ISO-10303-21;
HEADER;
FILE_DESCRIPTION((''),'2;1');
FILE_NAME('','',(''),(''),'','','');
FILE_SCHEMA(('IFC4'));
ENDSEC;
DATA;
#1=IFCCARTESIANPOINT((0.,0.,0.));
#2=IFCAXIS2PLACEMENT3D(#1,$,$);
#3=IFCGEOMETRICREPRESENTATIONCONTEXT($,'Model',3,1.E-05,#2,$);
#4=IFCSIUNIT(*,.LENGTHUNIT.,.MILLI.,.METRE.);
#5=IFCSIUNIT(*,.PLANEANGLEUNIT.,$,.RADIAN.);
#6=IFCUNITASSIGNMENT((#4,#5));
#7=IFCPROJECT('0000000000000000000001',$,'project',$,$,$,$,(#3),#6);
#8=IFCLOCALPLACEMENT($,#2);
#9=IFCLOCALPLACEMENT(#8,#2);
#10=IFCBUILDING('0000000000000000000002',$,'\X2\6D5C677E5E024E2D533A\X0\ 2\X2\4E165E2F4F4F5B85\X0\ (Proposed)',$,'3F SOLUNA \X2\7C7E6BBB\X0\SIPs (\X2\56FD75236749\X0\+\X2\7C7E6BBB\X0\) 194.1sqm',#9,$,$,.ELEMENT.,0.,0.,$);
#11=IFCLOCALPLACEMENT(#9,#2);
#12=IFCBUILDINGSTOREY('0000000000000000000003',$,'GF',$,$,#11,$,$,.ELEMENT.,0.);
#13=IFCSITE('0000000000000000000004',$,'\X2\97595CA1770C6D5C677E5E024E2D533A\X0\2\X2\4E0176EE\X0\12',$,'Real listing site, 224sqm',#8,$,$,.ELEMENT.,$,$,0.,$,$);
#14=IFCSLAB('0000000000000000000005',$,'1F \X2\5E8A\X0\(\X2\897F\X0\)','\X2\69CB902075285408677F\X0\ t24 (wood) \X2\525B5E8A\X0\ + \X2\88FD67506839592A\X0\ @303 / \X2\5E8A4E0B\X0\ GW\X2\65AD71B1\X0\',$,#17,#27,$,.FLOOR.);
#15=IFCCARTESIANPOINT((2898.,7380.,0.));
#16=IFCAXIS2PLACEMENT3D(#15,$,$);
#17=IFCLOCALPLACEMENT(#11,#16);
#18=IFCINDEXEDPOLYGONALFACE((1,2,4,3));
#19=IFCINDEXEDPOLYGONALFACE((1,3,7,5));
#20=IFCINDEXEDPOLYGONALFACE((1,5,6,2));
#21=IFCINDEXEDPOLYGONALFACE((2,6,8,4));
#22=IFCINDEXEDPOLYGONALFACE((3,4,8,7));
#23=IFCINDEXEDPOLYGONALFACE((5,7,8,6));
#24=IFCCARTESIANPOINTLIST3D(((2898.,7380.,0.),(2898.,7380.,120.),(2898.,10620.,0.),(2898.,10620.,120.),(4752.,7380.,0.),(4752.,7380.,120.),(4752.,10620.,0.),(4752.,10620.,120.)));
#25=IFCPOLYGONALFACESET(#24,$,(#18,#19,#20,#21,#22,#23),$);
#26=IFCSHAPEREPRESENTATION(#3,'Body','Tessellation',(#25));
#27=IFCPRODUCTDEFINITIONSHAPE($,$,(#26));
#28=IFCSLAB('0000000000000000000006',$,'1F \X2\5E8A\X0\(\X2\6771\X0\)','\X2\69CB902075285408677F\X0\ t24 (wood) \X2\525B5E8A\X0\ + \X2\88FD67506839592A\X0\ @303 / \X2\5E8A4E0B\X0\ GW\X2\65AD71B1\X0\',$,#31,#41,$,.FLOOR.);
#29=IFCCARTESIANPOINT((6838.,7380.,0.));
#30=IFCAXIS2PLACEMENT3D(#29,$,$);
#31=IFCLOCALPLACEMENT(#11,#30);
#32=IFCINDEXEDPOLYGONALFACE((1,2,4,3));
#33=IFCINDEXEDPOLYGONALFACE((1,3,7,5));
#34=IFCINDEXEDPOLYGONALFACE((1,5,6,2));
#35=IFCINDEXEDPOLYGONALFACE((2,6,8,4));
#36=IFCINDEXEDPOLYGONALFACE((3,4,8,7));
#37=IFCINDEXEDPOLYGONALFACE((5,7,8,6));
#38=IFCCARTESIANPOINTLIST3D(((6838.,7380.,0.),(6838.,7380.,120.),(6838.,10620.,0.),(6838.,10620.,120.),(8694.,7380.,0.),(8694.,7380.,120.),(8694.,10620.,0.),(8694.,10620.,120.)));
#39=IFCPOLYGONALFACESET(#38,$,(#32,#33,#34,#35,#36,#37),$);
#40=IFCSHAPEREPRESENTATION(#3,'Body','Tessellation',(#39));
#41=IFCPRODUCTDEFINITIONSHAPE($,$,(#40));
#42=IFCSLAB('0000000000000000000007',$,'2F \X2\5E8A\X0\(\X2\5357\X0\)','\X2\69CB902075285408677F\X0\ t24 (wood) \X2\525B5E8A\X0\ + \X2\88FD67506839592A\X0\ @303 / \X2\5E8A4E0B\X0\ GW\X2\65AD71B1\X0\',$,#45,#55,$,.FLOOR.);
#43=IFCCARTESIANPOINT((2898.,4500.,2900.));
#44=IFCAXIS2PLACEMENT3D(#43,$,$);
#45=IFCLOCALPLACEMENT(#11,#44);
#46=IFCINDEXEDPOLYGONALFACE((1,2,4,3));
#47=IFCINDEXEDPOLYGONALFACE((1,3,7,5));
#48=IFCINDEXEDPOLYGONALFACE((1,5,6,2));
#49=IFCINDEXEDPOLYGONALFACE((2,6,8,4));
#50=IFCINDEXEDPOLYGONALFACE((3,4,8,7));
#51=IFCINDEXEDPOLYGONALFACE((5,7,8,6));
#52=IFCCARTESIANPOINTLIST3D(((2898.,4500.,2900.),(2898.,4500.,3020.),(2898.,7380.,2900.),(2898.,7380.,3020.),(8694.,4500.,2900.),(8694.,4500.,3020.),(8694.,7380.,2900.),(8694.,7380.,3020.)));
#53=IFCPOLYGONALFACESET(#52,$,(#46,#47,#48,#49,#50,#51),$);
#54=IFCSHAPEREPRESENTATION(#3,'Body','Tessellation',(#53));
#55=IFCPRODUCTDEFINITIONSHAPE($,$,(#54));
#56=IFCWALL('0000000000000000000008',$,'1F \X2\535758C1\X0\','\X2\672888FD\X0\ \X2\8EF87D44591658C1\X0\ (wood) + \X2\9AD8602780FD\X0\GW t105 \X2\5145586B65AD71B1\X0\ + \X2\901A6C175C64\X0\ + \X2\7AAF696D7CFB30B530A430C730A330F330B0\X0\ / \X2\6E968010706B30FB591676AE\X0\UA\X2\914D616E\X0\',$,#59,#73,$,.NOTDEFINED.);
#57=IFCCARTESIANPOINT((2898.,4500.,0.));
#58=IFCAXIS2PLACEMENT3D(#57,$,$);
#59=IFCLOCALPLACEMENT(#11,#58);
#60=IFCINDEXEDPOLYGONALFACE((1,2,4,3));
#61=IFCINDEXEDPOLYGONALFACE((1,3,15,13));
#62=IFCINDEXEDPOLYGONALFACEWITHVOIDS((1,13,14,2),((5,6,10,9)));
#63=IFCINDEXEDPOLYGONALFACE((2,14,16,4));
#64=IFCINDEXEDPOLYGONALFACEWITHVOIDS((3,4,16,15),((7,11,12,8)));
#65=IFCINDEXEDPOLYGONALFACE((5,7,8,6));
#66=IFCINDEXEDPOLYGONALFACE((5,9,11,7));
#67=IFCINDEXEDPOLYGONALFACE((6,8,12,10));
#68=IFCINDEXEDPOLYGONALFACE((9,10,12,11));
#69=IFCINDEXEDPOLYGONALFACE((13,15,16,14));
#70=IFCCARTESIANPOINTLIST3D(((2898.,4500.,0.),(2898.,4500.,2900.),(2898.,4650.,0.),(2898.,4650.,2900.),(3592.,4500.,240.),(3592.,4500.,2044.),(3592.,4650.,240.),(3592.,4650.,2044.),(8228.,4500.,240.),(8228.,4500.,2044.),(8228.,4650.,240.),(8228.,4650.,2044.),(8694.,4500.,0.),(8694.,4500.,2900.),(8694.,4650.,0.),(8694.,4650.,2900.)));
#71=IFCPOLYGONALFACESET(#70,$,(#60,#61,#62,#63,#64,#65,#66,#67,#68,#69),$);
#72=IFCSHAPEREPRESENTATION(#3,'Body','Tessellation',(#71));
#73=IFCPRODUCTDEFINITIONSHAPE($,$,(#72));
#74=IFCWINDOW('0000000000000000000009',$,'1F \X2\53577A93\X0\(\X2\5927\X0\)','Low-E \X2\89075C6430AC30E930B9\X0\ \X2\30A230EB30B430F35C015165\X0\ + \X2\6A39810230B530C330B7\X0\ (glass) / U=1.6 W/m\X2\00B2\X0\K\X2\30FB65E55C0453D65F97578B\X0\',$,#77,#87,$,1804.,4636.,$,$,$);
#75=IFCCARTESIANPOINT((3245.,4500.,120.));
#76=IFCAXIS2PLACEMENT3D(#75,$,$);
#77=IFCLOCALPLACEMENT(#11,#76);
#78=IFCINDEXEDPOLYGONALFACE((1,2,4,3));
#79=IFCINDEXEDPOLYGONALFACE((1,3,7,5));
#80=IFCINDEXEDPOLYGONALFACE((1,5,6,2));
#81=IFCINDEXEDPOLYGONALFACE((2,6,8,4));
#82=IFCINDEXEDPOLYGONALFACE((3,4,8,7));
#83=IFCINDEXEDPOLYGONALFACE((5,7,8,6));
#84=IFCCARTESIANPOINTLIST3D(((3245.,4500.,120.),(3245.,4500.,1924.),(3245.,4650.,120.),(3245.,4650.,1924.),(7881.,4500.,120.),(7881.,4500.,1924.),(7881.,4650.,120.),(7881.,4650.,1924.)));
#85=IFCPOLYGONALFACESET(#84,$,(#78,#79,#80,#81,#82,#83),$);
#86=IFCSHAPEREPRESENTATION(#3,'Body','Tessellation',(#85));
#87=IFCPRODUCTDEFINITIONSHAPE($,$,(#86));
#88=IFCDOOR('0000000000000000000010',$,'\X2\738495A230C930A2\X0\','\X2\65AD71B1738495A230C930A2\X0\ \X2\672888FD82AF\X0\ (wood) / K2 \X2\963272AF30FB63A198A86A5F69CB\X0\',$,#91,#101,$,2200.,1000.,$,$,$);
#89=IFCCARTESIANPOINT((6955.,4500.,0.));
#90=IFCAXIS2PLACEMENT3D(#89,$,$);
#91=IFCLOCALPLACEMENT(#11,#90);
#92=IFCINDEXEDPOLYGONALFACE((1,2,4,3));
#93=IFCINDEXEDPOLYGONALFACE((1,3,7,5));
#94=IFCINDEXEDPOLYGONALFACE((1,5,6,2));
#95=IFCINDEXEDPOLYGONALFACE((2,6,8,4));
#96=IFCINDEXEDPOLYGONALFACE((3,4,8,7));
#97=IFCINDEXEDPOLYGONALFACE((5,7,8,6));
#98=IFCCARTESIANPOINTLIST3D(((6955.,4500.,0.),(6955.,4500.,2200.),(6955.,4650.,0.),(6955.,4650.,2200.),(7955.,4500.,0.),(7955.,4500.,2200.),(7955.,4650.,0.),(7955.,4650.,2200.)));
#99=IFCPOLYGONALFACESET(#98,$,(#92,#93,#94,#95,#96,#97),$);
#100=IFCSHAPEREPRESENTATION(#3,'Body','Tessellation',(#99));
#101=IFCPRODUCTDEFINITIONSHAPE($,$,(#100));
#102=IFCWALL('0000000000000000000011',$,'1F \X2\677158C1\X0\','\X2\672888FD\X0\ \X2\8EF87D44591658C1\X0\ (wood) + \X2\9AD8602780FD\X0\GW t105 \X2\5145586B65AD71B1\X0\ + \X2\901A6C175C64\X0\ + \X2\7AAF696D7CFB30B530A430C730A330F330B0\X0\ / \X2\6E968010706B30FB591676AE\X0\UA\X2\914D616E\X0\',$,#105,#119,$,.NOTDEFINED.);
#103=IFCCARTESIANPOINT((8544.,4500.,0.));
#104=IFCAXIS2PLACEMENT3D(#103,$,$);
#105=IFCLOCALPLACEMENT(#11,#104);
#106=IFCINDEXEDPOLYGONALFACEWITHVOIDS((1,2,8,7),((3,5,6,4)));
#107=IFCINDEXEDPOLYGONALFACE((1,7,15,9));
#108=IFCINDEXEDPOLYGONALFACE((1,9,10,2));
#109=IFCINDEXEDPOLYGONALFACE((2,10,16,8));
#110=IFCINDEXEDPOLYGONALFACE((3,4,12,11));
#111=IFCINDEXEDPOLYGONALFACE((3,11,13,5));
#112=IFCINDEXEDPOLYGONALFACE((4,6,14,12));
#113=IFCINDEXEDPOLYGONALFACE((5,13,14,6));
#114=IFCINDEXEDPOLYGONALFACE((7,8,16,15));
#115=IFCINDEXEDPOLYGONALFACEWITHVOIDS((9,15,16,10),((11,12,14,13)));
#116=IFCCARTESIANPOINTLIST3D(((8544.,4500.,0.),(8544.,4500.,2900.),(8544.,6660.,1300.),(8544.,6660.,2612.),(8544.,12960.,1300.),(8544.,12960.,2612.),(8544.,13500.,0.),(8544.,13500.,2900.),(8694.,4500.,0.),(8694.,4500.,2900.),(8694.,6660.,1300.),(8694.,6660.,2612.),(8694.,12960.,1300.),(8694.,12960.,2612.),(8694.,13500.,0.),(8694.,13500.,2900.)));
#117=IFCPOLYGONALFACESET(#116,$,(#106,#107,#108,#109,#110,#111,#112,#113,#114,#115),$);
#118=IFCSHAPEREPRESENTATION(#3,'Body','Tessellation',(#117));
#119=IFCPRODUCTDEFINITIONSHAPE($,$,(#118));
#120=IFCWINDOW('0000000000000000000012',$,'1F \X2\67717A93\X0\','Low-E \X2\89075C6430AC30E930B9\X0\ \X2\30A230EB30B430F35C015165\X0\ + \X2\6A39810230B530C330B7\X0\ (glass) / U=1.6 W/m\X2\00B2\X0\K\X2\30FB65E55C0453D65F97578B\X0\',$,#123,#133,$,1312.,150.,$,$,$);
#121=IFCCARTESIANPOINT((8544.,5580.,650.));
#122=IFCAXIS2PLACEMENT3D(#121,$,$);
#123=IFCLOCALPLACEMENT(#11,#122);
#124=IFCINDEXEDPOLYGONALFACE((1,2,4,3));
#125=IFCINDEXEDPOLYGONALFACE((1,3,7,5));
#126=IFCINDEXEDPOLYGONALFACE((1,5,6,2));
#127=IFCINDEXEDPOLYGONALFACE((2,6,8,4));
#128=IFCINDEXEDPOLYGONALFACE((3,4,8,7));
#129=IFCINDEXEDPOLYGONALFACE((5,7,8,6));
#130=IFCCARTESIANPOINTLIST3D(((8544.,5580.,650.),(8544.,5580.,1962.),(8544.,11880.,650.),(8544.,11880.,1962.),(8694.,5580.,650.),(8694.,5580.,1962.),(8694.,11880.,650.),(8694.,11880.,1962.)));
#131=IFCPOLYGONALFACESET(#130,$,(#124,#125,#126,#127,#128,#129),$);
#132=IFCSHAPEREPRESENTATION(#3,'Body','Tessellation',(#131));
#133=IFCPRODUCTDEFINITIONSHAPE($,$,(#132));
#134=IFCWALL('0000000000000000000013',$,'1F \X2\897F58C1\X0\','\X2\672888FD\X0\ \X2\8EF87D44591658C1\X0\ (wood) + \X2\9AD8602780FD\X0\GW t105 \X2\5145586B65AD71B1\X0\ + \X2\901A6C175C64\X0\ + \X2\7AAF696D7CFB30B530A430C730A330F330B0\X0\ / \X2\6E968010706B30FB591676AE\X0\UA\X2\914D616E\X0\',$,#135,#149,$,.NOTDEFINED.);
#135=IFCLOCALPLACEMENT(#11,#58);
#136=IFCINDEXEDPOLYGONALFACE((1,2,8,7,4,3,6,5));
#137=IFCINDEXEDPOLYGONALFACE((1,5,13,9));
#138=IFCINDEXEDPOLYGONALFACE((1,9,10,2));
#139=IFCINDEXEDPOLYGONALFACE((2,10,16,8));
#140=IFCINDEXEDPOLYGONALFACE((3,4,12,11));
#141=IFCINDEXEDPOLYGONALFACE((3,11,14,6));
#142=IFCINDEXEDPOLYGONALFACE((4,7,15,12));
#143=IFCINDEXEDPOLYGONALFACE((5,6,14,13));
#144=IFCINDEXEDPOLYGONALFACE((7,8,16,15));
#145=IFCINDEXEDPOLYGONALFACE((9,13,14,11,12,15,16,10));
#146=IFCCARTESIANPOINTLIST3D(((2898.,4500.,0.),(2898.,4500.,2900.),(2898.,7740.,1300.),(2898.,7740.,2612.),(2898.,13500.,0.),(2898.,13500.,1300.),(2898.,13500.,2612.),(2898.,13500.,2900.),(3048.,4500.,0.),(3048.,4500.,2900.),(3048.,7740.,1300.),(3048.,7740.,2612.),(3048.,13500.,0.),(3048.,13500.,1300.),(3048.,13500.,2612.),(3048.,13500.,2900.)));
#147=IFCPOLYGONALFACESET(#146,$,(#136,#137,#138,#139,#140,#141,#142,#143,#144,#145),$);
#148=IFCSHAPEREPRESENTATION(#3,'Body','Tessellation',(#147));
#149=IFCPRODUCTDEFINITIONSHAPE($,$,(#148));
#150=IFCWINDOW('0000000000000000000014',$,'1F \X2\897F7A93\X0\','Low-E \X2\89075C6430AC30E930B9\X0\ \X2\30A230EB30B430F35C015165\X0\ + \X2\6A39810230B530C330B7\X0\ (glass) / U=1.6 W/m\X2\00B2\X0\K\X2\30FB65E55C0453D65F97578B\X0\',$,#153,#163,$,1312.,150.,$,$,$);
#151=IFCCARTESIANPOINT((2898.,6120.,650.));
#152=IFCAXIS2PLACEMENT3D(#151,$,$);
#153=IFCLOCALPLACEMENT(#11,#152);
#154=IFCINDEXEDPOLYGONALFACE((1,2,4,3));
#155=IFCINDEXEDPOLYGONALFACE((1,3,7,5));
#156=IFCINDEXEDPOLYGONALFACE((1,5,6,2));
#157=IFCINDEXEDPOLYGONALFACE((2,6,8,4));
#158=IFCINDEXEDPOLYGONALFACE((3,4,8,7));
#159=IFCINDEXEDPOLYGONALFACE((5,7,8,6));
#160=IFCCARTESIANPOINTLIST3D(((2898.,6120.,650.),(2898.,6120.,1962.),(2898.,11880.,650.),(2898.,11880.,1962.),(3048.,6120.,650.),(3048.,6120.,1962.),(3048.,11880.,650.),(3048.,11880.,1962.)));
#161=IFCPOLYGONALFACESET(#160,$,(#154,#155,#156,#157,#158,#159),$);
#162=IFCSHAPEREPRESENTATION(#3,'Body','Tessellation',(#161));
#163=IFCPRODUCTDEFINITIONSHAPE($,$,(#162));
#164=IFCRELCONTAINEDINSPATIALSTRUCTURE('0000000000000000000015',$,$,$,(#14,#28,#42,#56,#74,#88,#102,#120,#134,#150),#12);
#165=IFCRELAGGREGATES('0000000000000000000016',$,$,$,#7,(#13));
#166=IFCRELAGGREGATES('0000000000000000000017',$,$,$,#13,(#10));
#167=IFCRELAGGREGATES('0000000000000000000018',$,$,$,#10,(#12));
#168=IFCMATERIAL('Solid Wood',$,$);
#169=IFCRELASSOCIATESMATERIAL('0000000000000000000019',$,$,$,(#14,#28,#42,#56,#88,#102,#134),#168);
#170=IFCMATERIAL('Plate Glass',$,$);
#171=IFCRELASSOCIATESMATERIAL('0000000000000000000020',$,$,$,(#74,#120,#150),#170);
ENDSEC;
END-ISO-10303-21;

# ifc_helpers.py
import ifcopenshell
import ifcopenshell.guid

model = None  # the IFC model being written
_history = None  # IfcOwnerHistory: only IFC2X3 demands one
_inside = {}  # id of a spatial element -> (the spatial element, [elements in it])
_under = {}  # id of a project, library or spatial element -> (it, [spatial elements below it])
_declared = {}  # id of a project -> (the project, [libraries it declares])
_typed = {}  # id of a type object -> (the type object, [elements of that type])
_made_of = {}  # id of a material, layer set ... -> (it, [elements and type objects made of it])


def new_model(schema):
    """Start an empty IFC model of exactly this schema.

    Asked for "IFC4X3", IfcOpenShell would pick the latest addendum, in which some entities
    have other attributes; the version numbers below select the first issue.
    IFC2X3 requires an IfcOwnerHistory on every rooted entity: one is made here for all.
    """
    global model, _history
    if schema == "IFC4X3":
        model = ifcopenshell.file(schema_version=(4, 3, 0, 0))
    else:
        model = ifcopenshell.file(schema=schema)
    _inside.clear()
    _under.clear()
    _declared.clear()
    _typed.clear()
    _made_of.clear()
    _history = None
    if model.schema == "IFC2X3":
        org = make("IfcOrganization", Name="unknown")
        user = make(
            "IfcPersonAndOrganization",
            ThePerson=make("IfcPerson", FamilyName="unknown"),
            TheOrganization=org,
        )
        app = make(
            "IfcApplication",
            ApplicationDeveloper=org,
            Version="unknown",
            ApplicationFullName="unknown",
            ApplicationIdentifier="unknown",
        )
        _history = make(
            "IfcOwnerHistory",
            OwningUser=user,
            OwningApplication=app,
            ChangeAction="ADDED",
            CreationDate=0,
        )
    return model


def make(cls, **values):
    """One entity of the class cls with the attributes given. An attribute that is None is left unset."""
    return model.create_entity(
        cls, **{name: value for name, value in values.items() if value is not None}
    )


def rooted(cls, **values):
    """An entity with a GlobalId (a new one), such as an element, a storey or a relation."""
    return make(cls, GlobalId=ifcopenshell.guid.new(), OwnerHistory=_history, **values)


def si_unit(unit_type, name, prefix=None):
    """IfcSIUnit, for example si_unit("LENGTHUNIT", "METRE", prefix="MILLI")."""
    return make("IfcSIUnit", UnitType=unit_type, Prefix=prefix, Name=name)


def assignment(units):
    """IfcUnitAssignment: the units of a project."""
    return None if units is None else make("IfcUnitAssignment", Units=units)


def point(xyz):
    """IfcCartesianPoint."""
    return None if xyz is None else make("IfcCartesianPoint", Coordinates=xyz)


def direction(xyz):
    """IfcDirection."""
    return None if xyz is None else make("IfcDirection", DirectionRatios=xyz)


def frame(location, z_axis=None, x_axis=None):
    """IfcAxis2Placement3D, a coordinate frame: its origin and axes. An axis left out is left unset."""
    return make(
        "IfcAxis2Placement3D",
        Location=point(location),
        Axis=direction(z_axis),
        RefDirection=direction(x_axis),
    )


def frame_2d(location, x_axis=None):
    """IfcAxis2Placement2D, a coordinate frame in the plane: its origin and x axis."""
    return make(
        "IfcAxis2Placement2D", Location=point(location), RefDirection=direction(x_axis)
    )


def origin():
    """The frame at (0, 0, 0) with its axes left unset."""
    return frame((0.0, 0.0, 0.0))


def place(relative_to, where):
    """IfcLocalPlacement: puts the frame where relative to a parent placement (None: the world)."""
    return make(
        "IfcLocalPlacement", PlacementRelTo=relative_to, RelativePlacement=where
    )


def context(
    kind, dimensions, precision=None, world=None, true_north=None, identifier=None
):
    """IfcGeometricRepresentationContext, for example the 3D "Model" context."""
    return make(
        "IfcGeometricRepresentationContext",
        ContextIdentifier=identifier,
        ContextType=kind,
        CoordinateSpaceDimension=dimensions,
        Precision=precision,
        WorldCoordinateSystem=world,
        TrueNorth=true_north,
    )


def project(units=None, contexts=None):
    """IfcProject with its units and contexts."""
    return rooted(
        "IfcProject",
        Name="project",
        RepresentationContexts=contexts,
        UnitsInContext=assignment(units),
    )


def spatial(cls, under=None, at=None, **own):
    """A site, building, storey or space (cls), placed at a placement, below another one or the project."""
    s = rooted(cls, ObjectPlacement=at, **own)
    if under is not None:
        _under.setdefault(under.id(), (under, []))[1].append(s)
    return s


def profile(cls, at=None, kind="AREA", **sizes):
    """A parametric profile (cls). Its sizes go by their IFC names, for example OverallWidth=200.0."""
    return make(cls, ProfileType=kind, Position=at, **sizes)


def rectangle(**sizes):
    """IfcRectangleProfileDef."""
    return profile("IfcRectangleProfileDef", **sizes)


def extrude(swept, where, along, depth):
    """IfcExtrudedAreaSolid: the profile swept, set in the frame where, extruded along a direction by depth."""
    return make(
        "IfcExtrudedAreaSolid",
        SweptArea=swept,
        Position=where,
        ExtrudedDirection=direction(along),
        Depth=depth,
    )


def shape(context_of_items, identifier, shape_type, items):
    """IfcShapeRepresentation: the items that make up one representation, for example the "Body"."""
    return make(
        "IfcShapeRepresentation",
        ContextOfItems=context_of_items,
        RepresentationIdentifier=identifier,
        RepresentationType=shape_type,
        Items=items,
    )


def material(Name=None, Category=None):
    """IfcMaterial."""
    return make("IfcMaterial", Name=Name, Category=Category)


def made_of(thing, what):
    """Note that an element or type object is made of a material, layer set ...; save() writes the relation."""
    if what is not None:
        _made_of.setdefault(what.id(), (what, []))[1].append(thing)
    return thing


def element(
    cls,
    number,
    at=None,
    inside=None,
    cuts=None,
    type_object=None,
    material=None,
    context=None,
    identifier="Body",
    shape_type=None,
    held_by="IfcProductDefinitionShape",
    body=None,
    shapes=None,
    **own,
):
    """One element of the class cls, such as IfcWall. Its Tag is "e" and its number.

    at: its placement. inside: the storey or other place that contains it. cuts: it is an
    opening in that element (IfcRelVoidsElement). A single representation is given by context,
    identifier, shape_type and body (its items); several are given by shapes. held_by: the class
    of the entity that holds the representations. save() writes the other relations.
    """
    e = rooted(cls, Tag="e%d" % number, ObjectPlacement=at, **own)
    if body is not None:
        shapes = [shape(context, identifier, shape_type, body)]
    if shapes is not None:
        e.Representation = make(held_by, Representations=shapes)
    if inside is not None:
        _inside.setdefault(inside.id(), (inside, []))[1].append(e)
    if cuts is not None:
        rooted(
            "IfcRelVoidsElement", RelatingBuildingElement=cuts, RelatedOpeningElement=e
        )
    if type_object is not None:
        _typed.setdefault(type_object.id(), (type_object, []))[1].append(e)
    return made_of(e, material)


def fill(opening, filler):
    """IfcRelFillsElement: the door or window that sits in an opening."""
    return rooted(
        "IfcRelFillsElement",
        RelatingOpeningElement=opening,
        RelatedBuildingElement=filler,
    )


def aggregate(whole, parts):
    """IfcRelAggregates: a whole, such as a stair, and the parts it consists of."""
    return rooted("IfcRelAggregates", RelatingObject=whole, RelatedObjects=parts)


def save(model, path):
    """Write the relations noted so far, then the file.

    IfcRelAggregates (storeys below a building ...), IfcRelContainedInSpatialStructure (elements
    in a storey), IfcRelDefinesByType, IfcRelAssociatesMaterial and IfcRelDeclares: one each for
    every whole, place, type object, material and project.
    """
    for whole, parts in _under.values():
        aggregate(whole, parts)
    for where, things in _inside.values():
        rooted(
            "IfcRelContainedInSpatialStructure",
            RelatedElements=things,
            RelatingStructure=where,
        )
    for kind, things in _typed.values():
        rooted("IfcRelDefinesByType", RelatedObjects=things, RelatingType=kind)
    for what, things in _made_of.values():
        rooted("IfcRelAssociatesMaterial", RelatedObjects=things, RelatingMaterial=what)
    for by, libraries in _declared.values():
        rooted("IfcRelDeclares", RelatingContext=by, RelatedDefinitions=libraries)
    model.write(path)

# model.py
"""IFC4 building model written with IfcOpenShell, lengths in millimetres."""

from ifc_helpers import new_model, si_unit, frame, frame_2d, origin, place, context, project, spatial, rectangle, extrude, material, element, fill, save


model = new_model("IFC4")

# Units and contexts
model_context = context("Model", 3, precision=1e-05, world=origin())
ifc_project = project(units=[si_unit("LENGTHUNIT", "METRE", prefix="MILLI"), si_unit("PLANEANGLEUNIT", "RADIAN")], contexts=[model_context])

# Site, building, storey
site_placement = place(None, origin())
site = spatial("IfcSite", under=ifc_project, at=site_placement, Name="静岡県浜松市中区2丁目12", ObjectType="Real listing site, 224sqm", CompositionType="ELEMENT", RefElevation=0.0)
building_placement = place(site_placement, origin())
building = spatial("IfcBuilding", under=site, at=building_placement, Name="浜松市中区 2世帯住宅 (Proposed)", ObjectType="3F SOLUNA 籾殻SIPs (国産杉+籾殻) 194.1sqm", CompositionType="ELEMENT", ElevationOfRefHeight=0.0, ElevationOfTerrain=0.0)
storey_placement = place(building_placement, origin())
storey = spatial("IfcBuildingStorey", under=building, at=storey_placement, Name="GF", CompositionType="ELEMENT", Elevation=0.0)

# Slabs
ifc_material_1 = material(Name="Solid Wood")
slab_1_placement = place(storey_placement, frame((2898.0, 7380.0, 0.0)))
element("IfcSlab", 1, at=slab_1_placement, inside=storey, material=ifc_material_1, Name="1F 床(西)", Description="構造用合板 t24 (wood) 剛床 + 製材根太 @303 / 床下 GW断熱", PredefinedType="FLOOR", context=model_context, shape_type="SweptSolid", body=[
    extrude(rectangle(XDim=1854.0, YDim=3240.0, at=frame_2d((927.0, 1620.0))), frame((2898.0, 7380.0, 0.0)), (0.0, 0.0, 1.0), 120.0),
])
slab_2_placement = place(storey_placement, frame((6838.0, 7380.0, 0.0)))
element("IfcSlab", 2, at=slab_2_placement, inside=storey, material=ifc_material_1, Name="1F 床(東)", Description="構造用合板 t24 (wood) 剛床 + 製材根太 @303 / 床下 GW断熱", PredefinedType="FLOOR", context=model_context, shape_type="SweptSolid", body=[
    extrude(rectangle(XDim=1856.0, YDim=3240.0, at=frame_2d((928.0, 1620.0))), frame((6838.0, 7380.0, 0.0)), (0.0, 0.0, 1.0), 120.0),
])
slab_3_placement = place(storey_placement, frame((2898.0, 4500.0, 2900.0)))
element("IfcSlab", 3, at=slab_3_placement, inside=storey, material=ifc_material_1, Name="2F 床(南)", Description="構造用合板 t24 (wood) 剛床 + 製材根太 @303 / 床下 GW断熱", PredefinedType="FLOOR", context=model_context, shape_type="SweptSolid", body=[
    extrude(rectangle(XDim=5796.0, YDim=2880.0, at=frame_2d((2898.0, 1440.0))), frame((2898.0, 4500.0, 2900.0)), (0.0, 0.0, 1.0), 120.0),
])

# Wall, openings, window, door
wall_1_placement = place(storey_placement, frame((2898.0, 4500.0, 0.0)))
wall_1 = element("IfcWall", 4, at=wall_1_placement, inside=storey, material=ifc_material_1, Name="1F 南壁", Description="木製 軸組外壁 (wood) + 高性能GW t105 充填断熱 + 通気層 + 窯業系サイディング / 準耐火・外皮UA配慮", PredefinedType="NOTDEFINED", context=model_context, shape_type="SweptSolid", body=[
    extrude(rectangle(XDim=5796.0, YDim=150.0, at=frame_2d((2898.0, 75.0))), frame((2898.0, 4500.0, 0.0)), (0.0, 0.0, 1.0), 2900.0),
])
opening_1_placement = place(storey_placement, frame((3245.0, 4500.0, 120.0)))
opening_1 = element("IfcOpeningElement", 5, at=opening_1_placement, cuts=wall_1, PredefinedType="NOTDEFINED", context=model_context, shape_type="SweptSolid", body=[
    extrude(rectangle(XDim=4636.0, YDim=150.0, at=frame_2d((2318.0, 75.0))), frame((3245.0, 4500.0, 120.0)), (0.0, 0.0, 1.0), 1804.0),
])
opening_2_placement = place(storey_placement, frame((6955.0, 4500.0, 0.0)))
opening_2 = element("IfcOpeningElement", 6, at=opening_2_placement, cuts=wall_1, PredefinedType="NOTDEFINED", context=model_context, shape_type="SweptSolid", body=[
    extrude(rectangle(XDim=1000.0, YDim=150.0, at=frame_2d((500.0, 75.0))), frame((6955.0, 4500.0, 0.0)), (0.0, 0.0, 1.0), 2200.0),
])
ifc_material_2 = material(Name="Plate Glass")
window_1_placement = place(storey_placement, frame((3245.0, 4500.0, 120.0)))
window_1 = element("IfcWindow", 7, at=window_1_placement, inside=storey, material=ifc_material_2, Name="1F 南窓(大)", Description="Low-E 複層ガラス アルゴン封入 + 樹脂サッシ (glass) / U=1.6 W/m²K・日射取得型", OverallHeight=1804.0, OverallWidth=4636.0, context=model_context, shape_type="SweptSolid", body=[
    extrude(rectangle(XDim=4636.0, YDim=150.0, at=frame_2d((2318.0, 75.0))), frame((3245.0, 4500.0, 120.0)), (0.0, 0.0, 1.0), 1804.0),
])
fill(opening_1, window_1)
door_placement = place(storey_placement, frame((6955.0, 4500.0, 0.0)))
door = element("IfcDoor", 8, at=door_placement, inside=storey, material=ifc_material_1, Name="玄関ドア", Description="断熱玄関ドア 木製芯 (wood) / K2 防犯・採風機構", OverallHeight=2200.0, OverallWidth=1000.0, context=model_context, shape_type="SweptSolid", body=[
    extrude(rectangle(XDim=1000.0, YDim=150.0, at=frame_2d((500.0, 75.0))), frame((6955.0, 4500.0, 0.0)), (0.0, 0.0, 1.0), 2200.0),
])
fill(opening_2, door)

# Walls, openings, windows
wall_2_placement = place(storey_placement, frame((8544.0, 4500.0, 0.0)))
wall_2 = element("IfcWall", 9, at=wall_2_placement, inside=storey, material=ifc_material_1, Name="1F 東壁", Description="木製 軸組外壁 (wood) + 高性能GW t105 充填断熱 + 通気層 + 窯業系サイディング / 準耐火・外皮UA配慮", PredefinedType="NOTDEFINED", context=model_context, shape_type="SweptSolid", body=[
    extrude(rectangle(XDim=150.0, YDim=9000.0, at=frame_2d((75.0, 4500.0))), frame((8544.0, 4500.0, 0.0)), (0.0, 0.0, 1.0), 2900.0),
])
opening_3_placement = place(storey_placement, frame((8544.0, 5580.0, 650.0)))
opening_3 = element("IfcOpeningElement", 10, at=opening_3_placement, cuts=wall_2, PredefinedType="NOTDEFINED", context=model_context, shape_type="SweptSolid", body=[
    extrude(rectangle(XDim=150.0, YDim=6300.0, at=frame_2d((75.0, 3150.0))), frame((8544.0, 5580.0, 650.0)), (0.0, 0.0, 1.0), 1312.0),
])
window_2_placement = place(storey_placement, frame((8544.0, 5580.0, 650.0)))
window_2 = element("IfcWindow", 11, at=window_2_placement, inside=storey, material=ifc_material_2, Name="1F 東窓", Description="Low-E 複層ガラス アルゴン封入 + 樹脂サッシ (glass) / U=1.6 W/m²K・日射取得型", OverallHeight=1312.0, OverallWidth=150.0, context=model_context, shape_type="SweptSolid", body=[
    extrude(rectangle(XDim=150.0, YDim=6300.0, at=frame_2d((75.0, 3150.0))), frame((8544.0, 5580.0, 650.0)), (0.0, 0.0, 1.0), 1312.0),
])
fill(opening_3, window_2)
wall_3_placement = place(storey_placement, frame((2898.0, 4500.0, 0.0)))
wall_3 = element("IfcWall", 12, at=wall_3_placement, inside=storey, material=ifc_material_1, Name="1F 西壁", Description="木製 軸組外壁 (wood) + 高性能GW t105 充填断熱 + 通気層 + 窯業系サイディング / 準耐火・外皮UA配慮", PredefinedType="NOTDEFINED", context=model_context, shape_type="SweptSolid", body=[
    extrude(rectangle(XDim=150.0, YDim=9000.0, at=frame_2d((75.0, 4500.0))), frame((2898.0, 4500.0, 0.0)), (0.0, 0.0, 1.0), 2900.0),
])
opening_4_placement = place(storey_placement, frame((2898.0, 6120.0, 650.0)))
opening_4 = element("IfcOpeningElement", 13, at=opening_4_placement, cuts=wall_3, PredefinedType="NOTDEFINED", context=model_context, shape_type="SweptSolid", body=[
    extrude(rectangle(XDim=150.0, YDim=5760.0, at=frame_2d((75.0, 2880.0))), frame((2898.0, 6120.0, 650.0)), (0.0, 0.0, 1.0), 1312.0),
])
window_3_placement = place(storey_placement, frame((2898.0, 6120.0, 650.0)))
window_3 = element("IfcWindow", 14, at=window_3_placement, inside=storey, material=ifc_material_2, Name="1F 西窓", Description="Low-E 複層ガラス アルゴン封入 + 樹脂サッシ (glass) / U=1.6 W/m²K・日射取得型", OverallHeight=1312.0, OverallWidth=150.0, context=model_context, shape_type="SweptSolid", body=[
    extrude(rectangle(XDim=150.0, YDim=5760.0, at=frame_2d((75.0, 2880.0))), frame((2898.0, 6120.0, 650.0)), (0.0, 0.0, 1.0), 1312.0),
])
fill(opening_4, window_3)

save(model, "model.ifc")
